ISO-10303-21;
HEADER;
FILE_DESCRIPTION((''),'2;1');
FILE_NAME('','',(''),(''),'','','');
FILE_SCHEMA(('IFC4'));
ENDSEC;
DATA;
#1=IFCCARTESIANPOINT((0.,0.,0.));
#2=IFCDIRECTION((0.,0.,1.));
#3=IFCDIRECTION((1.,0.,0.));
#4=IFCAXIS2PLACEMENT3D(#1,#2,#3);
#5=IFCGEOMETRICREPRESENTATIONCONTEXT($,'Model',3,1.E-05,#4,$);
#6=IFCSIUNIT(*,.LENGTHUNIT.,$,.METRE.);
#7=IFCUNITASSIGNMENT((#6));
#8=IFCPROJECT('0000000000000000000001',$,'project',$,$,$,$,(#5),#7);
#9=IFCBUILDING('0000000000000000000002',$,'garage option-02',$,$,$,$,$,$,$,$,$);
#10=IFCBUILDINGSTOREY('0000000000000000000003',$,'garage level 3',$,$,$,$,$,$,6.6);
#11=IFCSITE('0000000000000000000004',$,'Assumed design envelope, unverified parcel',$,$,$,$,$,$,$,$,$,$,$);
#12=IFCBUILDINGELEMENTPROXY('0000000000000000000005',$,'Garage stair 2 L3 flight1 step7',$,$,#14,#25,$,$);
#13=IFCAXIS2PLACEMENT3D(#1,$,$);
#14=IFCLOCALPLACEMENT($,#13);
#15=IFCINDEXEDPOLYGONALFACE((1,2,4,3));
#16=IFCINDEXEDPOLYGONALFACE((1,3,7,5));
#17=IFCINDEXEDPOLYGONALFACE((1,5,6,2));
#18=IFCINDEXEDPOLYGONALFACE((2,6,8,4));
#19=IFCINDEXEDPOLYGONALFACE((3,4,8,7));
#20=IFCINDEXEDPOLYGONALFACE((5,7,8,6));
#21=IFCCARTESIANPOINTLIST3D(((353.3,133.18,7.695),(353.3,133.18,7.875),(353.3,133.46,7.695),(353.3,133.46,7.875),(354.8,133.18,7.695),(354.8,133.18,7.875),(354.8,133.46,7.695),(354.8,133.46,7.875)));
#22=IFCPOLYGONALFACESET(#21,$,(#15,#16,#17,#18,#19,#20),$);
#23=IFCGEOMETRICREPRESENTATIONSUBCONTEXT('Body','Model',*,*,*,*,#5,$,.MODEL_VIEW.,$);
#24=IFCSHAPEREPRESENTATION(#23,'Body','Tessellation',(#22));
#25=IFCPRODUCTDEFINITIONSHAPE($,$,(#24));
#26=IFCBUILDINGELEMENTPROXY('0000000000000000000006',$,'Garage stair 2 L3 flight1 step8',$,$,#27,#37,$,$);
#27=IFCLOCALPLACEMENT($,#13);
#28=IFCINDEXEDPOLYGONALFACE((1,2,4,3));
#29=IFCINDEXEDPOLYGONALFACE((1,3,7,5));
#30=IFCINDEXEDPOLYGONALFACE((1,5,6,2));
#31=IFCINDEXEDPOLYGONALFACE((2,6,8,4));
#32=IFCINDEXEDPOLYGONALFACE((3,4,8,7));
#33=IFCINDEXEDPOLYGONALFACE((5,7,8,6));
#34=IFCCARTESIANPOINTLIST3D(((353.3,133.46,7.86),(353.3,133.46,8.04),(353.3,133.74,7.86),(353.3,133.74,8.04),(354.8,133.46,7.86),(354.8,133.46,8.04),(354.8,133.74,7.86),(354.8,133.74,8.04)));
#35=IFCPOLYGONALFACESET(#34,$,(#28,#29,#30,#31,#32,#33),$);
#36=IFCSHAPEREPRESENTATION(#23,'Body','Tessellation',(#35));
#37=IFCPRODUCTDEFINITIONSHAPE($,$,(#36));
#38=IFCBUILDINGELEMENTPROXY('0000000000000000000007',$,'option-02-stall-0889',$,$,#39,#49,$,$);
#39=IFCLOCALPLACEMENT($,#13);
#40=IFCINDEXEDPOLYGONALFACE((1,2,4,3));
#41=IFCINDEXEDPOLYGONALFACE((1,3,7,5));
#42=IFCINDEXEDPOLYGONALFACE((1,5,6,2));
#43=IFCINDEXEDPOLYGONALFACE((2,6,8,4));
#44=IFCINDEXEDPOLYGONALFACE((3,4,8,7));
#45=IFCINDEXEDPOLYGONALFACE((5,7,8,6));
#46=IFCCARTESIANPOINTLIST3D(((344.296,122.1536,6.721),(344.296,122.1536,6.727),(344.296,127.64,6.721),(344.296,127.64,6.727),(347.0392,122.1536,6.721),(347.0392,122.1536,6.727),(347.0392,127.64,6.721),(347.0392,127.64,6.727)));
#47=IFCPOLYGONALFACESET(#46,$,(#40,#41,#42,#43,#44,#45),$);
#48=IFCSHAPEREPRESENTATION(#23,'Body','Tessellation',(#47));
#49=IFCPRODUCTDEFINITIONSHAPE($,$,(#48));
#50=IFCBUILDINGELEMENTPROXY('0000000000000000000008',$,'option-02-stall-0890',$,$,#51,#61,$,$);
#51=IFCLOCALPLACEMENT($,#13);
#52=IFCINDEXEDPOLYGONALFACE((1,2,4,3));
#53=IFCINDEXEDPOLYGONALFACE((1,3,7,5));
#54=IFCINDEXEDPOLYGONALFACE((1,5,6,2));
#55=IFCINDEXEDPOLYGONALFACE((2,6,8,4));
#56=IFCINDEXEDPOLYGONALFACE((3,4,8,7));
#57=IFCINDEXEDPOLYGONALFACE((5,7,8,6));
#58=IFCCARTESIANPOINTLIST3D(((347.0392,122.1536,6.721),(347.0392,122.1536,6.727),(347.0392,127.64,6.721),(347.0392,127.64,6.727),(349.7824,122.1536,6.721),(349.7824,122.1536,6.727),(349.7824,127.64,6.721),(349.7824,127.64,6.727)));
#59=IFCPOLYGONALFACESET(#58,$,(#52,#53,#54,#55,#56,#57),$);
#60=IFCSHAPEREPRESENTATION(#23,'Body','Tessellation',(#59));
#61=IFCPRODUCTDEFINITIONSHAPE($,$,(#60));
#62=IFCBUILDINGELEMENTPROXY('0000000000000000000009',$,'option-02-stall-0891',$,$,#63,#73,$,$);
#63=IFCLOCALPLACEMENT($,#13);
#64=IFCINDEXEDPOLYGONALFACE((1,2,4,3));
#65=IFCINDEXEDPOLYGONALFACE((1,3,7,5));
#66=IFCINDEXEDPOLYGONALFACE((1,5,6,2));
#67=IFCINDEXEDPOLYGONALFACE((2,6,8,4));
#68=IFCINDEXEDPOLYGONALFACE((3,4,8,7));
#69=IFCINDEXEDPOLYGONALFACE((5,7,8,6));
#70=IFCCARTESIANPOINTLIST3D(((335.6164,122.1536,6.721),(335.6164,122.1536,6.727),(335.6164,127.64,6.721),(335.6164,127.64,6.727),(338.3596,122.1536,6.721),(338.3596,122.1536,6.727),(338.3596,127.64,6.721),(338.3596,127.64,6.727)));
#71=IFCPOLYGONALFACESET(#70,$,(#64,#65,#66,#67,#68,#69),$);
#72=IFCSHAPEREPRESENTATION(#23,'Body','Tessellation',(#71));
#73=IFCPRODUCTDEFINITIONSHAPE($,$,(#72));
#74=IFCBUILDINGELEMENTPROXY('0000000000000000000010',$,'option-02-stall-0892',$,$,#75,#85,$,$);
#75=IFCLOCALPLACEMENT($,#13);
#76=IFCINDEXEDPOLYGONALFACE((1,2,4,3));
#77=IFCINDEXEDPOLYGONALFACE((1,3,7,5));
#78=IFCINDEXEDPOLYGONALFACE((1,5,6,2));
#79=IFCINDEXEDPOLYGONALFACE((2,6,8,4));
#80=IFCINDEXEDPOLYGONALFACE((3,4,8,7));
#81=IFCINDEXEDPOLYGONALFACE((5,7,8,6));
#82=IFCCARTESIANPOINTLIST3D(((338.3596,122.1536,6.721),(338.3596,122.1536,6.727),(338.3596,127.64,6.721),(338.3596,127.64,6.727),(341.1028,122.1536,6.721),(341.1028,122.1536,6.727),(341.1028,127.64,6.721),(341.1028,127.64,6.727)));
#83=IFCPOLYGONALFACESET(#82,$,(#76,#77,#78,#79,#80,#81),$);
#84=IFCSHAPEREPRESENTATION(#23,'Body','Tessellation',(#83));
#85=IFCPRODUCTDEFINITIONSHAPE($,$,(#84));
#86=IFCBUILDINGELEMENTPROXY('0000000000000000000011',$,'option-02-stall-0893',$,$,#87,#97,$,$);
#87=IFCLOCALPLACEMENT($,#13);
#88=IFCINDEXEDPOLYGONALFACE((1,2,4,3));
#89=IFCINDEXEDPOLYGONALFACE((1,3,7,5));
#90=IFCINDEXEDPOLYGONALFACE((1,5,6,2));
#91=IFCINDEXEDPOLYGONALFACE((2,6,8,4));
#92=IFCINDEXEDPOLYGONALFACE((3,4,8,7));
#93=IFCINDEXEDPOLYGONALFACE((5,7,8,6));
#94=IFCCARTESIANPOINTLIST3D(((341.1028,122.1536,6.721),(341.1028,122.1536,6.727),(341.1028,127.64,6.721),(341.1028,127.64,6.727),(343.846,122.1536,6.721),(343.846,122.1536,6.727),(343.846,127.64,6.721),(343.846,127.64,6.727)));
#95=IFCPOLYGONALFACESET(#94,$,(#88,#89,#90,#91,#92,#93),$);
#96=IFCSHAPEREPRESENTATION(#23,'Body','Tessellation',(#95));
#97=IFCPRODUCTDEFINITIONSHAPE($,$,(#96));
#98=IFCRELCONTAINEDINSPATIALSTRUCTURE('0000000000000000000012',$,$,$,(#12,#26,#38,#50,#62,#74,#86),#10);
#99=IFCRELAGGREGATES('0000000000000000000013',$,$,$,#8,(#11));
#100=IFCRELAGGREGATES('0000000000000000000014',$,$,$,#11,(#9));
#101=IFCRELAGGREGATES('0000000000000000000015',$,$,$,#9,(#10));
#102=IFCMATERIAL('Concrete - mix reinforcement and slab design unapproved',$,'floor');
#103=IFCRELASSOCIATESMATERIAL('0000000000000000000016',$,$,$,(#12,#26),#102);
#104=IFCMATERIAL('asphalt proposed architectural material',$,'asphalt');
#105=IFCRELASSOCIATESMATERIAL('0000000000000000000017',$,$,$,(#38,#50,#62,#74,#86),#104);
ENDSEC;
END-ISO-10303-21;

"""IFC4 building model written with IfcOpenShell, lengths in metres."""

from ifc_helpers import new_model, si_unit, frame, origin_with_axes, place, context, subcontext, project, spatial, rectangle, extrude, material, element, save


model = new_model("IFC4")

# Units and contexts
model_context = context("Model", 3, precision=1e-05, world=origin_with_axes())
body_context = subcontext(model_context, "Body", "Model", "MODEL_VIEW")
ifc_project = project(units=[si_unit("LENGTHUNIT", "METRE")], contexts=[model_context])

# Site, building, storey
site = spatial("IfcSite", under=ifc_project, Name="Assumed design envelope, unverified parcel")
building = spatial("IfcBuilding", under=site, Name="garage option-02")
storey = spatial("IfcBuildingStorey", under=building, Name="garage level 3", Elevation=6.6)

# Shared definitions
ifc_material_1 = material(Name="Concrete - mix reinforcement and slab design unapproved", Category="floor")

# Building element proxies
for number, where, z_axis, x_axis, name in (
    (1, (354.05, 133.32, 7.695), (0.0, 0.0, 1.0), (1.0, 0.0, 0.0), "Garage stair 2 L3 flight1 step7"),
    (2, (354.05, 133.6, 7.86), (0.0, 0.0, 1.0), (1.0, 0.0, 0.0), "Garage stair 2 L3 flight1 step8"),
):
    element("IfcBuildingElementProxy", number, at=place(None, frame(where, z_axis=z_axis, x_axis=x_axis)), inside=storey, material=ifc_material_1, Name=name, context=body_context, shape_type="SweptSolid", body=[
        extrude(rectangle(XDim=1.5, YDim=0.28), origin_with_axes(), (0.0, 0.0, 1.0), 0.18),
    ])
ifc_material_2 = material(Name="asphalt proposed architectural material", Category="asphalt")
for number, where, z_axis, x_axis, name in (
    (3, (345.6676, 124.8968, 6.721), (0.0, 0.0, 1.0), (1.0, 0.0, 0.0), "option-02-stall-0889"),
    (4, (348.4108, 124.8968, 6.721), (0.0, 0.0, 1.0), (1.0, 0.0, 0.0), "option-02-stall-0890"),
    (5, (336.988, 124.8968, 6.721), (0.0, 0.0, 1.0), (1.0, 0.0, 0.0), "option-02-stall-0891"),
    (6, (339.7312, 124.8968, 6.721), (0.0, 0.0, 1.0), (1.0, 0.0, 0.0), "option-02-stall-0892"),
    (7, (342.4744, 124.8968, 6.721), (0.0, 0.0, 1.0), (1.0, 0.0, 0.0), "option-02-stall-0893"),
):
    element("IfcBuildingElementProxy", number, at=place(None, frame(where, z_axis=z_axis, x_axis=x_axis)), inside=storey, material=ifc_material_2, Name=name, context=body_context, shape_type="SweptSolid", body=[
        extrude(rectangle(XDim=2.7432, YDim=5.4864), origin_with_axes(), (0.0, 0.0, 1.0), 0.006),
    ])

save(model, "model.ifc")
